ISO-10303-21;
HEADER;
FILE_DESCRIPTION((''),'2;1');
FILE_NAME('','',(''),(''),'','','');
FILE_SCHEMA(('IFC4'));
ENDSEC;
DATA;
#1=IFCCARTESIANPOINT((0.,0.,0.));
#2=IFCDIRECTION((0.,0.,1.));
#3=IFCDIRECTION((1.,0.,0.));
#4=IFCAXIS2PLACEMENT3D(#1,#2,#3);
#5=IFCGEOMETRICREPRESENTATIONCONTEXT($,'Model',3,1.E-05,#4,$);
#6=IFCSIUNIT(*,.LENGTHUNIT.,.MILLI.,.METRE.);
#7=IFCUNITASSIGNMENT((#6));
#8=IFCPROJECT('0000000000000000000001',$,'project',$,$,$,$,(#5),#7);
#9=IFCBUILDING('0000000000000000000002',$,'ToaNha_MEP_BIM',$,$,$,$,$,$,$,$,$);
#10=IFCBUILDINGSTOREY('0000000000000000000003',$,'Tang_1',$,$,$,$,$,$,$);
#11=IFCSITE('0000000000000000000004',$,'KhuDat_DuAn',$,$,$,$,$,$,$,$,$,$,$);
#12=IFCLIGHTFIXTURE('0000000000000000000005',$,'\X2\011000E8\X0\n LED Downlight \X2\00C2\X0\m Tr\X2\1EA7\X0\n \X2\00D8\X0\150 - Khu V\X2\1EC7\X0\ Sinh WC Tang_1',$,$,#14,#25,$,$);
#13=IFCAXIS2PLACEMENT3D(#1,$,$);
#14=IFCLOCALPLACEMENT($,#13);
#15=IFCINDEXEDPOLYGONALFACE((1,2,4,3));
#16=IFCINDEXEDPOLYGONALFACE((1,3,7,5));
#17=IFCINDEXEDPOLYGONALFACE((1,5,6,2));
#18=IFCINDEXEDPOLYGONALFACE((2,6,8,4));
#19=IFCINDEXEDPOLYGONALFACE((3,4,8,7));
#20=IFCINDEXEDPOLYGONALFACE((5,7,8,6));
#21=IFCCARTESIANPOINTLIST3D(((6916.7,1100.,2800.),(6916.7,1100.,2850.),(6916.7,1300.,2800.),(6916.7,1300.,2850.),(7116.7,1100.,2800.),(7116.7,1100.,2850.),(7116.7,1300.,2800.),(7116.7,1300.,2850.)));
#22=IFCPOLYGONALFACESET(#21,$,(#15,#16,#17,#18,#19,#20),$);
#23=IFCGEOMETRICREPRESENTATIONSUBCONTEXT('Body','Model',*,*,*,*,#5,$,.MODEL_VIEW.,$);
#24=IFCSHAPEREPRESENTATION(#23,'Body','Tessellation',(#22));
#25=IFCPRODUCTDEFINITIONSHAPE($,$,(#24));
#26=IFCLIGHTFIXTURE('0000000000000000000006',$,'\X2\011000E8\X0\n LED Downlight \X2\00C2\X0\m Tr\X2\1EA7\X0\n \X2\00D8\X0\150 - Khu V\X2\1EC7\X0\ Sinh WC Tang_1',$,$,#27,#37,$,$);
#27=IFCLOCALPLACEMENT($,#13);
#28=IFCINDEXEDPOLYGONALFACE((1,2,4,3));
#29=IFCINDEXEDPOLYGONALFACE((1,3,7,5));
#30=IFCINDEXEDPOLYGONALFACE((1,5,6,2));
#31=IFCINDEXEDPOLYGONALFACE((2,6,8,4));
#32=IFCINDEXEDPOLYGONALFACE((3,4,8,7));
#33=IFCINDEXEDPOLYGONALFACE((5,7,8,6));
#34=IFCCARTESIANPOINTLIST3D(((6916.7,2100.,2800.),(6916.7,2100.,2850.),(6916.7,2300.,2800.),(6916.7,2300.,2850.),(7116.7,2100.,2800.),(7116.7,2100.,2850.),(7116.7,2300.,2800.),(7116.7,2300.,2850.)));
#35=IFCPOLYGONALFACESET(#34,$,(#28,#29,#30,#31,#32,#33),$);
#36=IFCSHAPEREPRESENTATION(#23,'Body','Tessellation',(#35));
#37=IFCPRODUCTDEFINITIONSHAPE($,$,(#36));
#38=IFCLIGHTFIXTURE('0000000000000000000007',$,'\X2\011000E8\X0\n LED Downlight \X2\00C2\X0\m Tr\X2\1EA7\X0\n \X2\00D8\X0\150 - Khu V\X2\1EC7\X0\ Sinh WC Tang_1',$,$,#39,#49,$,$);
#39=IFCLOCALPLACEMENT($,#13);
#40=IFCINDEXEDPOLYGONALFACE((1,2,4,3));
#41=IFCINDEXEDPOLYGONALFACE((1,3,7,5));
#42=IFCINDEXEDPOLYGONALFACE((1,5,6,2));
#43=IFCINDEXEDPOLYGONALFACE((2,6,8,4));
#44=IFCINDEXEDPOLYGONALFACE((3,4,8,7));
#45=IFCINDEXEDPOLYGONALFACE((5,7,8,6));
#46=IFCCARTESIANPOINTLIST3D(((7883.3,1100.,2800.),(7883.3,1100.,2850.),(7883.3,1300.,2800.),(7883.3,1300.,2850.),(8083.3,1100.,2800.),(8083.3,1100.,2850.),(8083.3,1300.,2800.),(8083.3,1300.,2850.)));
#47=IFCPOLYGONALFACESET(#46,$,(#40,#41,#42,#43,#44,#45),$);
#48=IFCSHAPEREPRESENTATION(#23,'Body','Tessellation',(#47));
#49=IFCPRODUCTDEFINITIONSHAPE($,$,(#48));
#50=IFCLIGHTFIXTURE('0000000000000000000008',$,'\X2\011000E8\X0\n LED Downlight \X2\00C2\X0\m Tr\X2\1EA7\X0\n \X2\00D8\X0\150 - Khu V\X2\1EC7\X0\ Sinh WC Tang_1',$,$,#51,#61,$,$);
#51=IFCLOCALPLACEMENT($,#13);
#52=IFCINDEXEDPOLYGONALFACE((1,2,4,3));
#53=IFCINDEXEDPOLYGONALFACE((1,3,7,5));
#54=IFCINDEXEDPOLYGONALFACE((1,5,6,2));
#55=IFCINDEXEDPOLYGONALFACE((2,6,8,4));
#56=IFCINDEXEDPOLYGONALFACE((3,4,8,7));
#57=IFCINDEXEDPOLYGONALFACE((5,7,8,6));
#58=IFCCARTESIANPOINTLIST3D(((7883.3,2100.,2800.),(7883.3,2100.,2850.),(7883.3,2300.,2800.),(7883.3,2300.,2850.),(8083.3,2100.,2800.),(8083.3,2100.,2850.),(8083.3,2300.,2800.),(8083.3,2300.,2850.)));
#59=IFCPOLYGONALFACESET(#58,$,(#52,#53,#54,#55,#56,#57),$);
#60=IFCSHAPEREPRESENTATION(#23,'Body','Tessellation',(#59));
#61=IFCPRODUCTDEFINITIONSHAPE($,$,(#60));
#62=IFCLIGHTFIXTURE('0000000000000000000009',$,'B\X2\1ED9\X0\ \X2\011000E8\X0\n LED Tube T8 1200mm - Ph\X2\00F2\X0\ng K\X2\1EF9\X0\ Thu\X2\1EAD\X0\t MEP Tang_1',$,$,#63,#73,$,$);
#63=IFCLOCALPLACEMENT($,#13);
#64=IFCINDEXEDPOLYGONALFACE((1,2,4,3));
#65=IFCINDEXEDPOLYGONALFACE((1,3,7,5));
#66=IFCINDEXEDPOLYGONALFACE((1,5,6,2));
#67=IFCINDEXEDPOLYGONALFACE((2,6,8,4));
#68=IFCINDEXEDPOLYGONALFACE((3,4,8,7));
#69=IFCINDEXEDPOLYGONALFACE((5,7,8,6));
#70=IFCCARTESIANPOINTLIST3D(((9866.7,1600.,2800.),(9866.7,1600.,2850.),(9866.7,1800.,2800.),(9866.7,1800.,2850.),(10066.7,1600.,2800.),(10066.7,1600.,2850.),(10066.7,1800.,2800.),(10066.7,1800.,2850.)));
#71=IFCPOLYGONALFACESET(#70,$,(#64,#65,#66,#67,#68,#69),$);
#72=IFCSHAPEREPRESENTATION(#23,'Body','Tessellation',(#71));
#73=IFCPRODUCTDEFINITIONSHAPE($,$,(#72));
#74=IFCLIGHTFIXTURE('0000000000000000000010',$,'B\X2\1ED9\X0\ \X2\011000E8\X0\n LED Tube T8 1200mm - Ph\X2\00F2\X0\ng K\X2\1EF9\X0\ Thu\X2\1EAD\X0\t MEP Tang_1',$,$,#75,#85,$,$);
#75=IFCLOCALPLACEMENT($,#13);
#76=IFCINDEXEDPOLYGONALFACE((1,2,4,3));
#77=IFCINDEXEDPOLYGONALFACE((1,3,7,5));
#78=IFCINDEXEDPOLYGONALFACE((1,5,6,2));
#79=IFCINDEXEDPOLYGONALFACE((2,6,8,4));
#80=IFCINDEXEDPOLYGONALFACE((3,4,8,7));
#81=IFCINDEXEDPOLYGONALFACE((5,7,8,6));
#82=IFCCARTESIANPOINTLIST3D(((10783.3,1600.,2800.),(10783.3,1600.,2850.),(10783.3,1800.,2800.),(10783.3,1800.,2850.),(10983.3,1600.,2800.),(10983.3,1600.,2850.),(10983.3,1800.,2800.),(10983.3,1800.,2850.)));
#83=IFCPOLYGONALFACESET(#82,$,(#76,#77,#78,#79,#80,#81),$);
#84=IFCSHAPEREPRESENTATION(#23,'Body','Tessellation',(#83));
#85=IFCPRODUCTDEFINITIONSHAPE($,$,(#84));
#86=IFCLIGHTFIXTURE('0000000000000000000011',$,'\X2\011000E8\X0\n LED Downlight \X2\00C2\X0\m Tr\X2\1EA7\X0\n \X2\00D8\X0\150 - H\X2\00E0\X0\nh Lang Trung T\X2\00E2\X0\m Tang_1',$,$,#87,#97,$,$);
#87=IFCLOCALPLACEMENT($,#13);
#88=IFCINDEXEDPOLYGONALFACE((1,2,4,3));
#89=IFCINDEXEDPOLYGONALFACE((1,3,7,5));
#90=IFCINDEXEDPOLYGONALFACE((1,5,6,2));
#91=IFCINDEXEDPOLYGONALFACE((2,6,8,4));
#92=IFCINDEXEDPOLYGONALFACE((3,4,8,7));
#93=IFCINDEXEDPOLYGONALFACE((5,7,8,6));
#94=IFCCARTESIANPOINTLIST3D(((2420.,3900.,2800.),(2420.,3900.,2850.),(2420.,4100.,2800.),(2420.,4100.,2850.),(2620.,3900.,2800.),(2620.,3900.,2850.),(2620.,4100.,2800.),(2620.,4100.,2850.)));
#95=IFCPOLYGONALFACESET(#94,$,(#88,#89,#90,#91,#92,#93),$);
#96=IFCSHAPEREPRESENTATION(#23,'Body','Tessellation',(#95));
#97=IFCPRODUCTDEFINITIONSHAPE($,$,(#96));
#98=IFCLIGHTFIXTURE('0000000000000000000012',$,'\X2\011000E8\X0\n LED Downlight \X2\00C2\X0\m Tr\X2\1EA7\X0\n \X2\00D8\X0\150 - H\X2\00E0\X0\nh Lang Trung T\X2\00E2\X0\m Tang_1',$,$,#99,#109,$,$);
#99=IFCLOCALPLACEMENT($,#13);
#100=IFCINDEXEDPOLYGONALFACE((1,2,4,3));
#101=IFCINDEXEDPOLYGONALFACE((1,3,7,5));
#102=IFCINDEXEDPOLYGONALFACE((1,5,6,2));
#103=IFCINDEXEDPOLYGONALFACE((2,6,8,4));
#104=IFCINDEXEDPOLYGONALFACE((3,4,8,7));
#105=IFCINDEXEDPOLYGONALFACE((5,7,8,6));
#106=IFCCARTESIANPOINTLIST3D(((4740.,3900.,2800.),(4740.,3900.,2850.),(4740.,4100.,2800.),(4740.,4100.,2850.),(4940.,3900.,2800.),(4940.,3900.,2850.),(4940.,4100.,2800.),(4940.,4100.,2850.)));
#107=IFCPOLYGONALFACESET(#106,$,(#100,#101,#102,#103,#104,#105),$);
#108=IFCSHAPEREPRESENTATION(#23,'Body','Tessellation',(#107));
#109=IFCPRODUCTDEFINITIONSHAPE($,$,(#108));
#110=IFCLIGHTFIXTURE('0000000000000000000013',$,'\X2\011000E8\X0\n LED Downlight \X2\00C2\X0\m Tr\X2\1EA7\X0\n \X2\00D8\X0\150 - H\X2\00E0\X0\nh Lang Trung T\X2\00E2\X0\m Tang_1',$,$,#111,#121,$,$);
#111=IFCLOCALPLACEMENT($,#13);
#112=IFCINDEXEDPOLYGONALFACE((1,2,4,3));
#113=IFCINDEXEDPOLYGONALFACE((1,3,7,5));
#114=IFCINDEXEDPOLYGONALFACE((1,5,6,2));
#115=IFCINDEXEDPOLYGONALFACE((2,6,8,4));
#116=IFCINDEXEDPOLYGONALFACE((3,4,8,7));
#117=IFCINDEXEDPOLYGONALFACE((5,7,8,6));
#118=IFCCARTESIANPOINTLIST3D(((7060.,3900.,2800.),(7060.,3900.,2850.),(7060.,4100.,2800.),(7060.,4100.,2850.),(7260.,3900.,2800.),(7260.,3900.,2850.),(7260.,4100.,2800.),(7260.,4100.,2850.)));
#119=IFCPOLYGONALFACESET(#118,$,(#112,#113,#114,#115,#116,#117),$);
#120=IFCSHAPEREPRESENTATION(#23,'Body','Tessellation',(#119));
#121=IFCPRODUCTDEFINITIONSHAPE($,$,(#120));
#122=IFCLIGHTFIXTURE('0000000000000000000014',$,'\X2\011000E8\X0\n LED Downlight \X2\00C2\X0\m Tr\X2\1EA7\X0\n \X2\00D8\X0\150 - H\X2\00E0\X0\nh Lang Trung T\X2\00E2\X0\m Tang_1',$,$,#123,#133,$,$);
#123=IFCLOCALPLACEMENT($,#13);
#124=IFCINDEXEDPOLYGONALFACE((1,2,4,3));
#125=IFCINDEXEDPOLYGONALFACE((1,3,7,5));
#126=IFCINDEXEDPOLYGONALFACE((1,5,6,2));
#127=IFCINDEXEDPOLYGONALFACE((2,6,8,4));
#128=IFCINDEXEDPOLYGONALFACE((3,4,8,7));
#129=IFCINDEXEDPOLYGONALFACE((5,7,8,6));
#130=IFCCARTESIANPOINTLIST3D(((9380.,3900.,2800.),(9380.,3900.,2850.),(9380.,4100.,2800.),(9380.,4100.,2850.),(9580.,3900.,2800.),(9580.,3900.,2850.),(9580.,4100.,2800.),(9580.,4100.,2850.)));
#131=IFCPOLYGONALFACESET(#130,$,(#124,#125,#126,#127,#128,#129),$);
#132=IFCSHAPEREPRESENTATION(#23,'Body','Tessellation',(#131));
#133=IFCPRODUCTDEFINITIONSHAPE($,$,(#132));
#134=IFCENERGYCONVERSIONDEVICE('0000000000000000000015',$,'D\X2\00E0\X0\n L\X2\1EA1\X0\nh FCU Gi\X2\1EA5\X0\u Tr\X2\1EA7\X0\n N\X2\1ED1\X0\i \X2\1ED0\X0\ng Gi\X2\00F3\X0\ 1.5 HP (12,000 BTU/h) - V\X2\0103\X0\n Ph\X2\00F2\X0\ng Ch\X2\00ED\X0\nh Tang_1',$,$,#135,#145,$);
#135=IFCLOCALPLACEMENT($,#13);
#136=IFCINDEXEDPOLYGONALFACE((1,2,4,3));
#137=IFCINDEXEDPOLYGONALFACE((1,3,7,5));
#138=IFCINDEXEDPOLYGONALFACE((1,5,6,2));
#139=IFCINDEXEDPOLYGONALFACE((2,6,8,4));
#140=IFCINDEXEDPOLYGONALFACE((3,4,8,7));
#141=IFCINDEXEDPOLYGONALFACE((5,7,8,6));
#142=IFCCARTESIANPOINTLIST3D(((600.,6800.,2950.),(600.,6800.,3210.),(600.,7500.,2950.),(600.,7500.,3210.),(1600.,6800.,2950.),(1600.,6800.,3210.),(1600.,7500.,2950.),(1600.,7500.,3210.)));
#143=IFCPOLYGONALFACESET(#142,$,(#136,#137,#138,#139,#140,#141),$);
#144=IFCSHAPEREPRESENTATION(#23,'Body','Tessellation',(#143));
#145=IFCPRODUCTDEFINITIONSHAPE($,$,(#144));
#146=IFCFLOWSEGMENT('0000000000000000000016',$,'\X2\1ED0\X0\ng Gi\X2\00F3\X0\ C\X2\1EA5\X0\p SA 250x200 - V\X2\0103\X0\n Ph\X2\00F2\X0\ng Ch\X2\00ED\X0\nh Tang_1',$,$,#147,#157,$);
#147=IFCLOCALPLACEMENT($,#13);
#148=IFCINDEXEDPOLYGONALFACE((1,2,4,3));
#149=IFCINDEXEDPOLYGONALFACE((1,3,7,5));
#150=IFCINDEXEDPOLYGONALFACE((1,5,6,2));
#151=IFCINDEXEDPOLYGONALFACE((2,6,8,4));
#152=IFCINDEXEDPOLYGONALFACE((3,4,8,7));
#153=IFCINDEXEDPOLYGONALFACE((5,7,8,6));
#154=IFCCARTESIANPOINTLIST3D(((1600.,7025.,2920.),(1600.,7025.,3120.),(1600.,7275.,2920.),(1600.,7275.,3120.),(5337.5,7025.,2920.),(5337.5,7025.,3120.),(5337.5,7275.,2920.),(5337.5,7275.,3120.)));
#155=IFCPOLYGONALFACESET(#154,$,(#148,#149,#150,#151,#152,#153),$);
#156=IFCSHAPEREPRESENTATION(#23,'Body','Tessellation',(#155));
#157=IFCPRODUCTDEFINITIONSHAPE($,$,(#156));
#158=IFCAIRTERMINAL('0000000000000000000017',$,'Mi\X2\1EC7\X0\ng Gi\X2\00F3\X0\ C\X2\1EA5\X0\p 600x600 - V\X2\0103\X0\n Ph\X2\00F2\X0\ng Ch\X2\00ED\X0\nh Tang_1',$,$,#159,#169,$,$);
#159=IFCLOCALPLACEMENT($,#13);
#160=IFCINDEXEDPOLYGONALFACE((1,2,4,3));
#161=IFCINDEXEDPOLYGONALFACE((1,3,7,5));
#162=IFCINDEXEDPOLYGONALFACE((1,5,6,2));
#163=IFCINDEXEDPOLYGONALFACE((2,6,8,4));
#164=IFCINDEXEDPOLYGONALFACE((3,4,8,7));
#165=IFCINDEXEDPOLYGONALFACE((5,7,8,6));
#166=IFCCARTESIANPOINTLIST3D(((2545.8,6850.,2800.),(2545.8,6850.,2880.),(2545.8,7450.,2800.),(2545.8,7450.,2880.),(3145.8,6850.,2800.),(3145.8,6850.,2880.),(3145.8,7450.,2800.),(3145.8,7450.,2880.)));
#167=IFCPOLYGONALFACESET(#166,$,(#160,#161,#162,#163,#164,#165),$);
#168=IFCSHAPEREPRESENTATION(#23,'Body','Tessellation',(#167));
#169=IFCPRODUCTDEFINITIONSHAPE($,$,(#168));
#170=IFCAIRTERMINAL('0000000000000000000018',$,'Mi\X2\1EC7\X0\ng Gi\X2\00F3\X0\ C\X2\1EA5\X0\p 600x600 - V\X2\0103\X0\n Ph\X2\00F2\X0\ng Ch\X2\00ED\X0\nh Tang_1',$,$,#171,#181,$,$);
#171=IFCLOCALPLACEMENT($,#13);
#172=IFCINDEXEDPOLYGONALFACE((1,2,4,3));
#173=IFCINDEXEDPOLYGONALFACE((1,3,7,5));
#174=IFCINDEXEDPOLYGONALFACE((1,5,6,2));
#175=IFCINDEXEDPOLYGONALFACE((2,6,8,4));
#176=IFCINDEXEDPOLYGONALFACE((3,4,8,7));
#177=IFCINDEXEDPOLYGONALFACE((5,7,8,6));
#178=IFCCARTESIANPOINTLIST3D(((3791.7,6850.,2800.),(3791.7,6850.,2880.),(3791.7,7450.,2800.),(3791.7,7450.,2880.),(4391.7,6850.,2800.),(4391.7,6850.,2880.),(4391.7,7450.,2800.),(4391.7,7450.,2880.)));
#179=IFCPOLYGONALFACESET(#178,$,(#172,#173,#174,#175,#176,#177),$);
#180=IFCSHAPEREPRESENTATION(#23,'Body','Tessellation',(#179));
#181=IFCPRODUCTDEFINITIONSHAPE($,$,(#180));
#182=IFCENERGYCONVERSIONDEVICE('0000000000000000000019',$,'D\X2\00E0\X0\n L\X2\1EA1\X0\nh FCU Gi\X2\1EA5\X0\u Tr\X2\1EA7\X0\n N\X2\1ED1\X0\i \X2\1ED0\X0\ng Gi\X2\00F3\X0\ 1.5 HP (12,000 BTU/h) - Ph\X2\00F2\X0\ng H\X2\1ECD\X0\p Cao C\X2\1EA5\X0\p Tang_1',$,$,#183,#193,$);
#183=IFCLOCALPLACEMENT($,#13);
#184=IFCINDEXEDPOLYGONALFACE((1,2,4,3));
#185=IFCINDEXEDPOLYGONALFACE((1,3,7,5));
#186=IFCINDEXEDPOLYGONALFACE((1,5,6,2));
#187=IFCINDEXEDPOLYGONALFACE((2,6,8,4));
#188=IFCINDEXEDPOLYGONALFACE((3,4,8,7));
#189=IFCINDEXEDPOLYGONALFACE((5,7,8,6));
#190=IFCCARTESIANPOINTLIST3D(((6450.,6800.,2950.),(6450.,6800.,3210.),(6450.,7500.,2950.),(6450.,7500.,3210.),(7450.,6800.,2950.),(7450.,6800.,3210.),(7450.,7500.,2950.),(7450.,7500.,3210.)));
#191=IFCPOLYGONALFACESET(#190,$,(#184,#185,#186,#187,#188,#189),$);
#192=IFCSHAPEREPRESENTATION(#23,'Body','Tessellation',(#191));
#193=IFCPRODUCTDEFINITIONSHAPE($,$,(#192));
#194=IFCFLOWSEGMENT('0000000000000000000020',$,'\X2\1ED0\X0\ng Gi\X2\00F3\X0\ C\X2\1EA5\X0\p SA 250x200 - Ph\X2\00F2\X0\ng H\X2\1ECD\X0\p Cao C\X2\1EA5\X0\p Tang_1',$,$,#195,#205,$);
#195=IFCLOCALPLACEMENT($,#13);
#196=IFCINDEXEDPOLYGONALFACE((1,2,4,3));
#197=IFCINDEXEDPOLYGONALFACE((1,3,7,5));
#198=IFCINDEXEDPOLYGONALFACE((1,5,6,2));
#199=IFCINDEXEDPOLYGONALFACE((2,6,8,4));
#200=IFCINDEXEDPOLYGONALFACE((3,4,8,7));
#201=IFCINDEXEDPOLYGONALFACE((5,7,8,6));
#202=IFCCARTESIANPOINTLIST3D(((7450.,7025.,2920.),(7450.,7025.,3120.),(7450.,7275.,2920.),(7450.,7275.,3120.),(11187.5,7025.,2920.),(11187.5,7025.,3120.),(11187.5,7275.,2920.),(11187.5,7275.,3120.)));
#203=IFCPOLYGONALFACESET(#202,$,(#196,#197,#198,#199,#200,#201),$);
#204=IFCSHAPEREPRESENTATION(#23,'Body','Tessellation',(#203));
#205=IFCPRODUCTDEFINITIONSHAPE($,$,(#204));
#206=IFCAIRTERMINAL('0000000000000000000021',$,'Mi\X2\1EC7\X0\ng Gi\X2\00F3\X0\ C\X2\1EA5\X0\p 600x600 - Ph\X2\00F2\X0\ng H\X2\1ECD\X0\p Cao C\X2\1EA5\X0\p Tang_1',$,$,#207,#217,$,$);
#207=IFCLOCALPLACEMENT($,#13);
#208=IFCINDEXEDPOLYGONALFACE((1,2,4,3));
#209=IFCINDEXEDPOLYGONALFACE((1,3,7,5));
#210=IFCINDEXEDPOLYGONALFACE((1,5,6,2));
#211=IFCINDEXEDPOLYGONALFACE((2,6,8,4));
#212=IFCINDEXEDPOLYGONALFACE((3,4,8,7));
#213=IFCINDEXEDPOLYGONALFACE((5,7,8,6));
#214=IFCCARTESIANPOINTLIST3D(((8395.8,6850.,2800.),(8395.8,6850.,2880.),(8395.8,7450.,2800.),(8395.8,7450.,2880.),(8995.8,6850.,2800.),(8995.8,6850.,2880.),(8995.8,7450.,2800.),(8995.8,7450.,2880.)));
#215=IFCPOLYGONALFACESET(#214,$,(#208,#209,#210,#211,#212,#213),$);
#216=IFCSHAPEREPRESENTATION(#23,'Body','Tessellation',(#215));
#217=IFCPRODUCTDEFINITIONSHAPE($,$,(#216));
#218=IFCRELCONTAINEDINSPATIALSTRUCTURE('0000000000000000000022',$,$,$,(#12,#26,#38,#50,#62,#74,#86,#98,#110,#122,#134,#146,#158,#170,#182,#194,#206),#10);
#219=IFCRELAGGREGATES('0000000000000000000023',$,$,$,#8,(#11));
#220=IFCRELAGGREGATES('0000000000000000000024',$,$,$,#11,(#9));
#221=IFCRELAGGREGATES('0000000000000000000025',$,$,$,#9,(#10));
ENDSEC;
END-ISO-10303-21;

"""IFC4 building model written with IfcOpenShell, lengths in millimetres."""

from ifc_helpers import new_model, si_unit, frame, origin_with_axes, context, subcontext, project, spatial, polyline, outline, extrude, element, save


model = new_model("IFC4")

# Units and contexts
model_context = context("Model", 3, precision=1e-05, world=origin_with_axes())
body_context = subcontext(model_context, "Body", "Model", "MODEL_VIEW")
ifc_project = project(units=[si_unit("LENGTHUNIT", "METRE", prefix="MILLI")], contexts=[model_context])

# Site, building, storey
site = spatial("IfcSite", under=ifc_project, Name="KhuDat_DuAn")
building = spatial("IfcBuilding", under=site, Name="ToaNha_MEP_BIM")
storey = spatial("IfcBuildingStorey", under=building, Name="Tang_1")

# Light fixtures
element("IfcLightFixture", 1, inside=storey, Name="Đèn LED Downlight Âm Trần Ø150 - Khu Vệ Sinh WC Tang_1", context=body_context, shape_type="SweptSolid", body=[
    extrude(outline(polyline([(6916.7, 1100.0), (7116.7, 1100.0), (7116.7, 1300.0), (6916.7, 1300.0), (6916.7, 1100.0)])), frame((0.0, 0.0, 2800.0), z_axis=(0.0, 0.0, 1.0), x_axis=(1.0, 0.0, 0.0)), (0.0, 0.0, 1.0), 50.0),
])
element("IfcLightFixture", 2, inside=storey, Name="Đèn LED Downlight Âm Trần Ø150 - Khu Vệ Sinh WC Tang_1", context=body_context, shape_type="SweptSolid", body=[
    extrude(outline(polyline([(6916.7, 2100.0), (7116.7, 2100.0), (7116.7, 2300.0), (6916.7, 2300.0), (6916.7, 2100.0)])), frame((0.0, 0.0, 2800.0), z_axis=(0.0, 0.0, 1.0), x_axis=(1.0, 0.0, 0.0)), (0.0, 0.0, 1.0), 50.0),
])
element("IfcLightFixture", 3, inside=storey, Name="Đèn LED Downlight Âm Trần Ø150 - Khu Vệ Sinh WC Tang_1", context=body_context, shape_type="SweptSolid", body=[
    extrude(outline(polyline([(7883.3, 1100.0), (8083.3, 1100.0), (8083.3, 1300.0), (7883.3, 1300.0), (7883.3, 1100.0)])), frame((0.0, 0.0, 2800.0), z_axis=(0.0, 0.0, 1.0), x_axis=(1.0, 0.0, 0.0)), (0.0, 0.0, 1.0), 50.0),
])
element("IfcLightFixture", 4, inside=storey, Name="Đèn LED Downlight Âm Trần Ø150 - Khu Vệ Sinh WC Tang_1", context=body_context, shape_type="SweptSolid", body=[
    extrude(outline(polyline([(7883.3, 2100.0), (8083.3, 2100.0), (8083.3, 2300.0), (7883.3, 2300.0), (7883.3, 2100.0)])), frame((0.0, 0.0, 2800.0), z_axis=(0.0, 0.0, 1.0), x_axis=(1.0, 0.0, 0.0)), (0.0, 0.0, 1.0), 50.0),
])
element("IfcLightFixture", 5, inside=storey, Name="Bộ Đèn LED Tube T8 1200mm - Phòng Kỹ Thuật MEP Tang_1", context=body_context, shape_type="SweptSolid", body=[
    extrude(outline(polyline([(9866.7, 1600.0), (10066.7, 1600.0), (10066.7, 1800.0), (9866.7, 1800.0), (9866.7, 1600.0)])), frame((0.0, 0.0, 2800.0), z_axis=(0.0, 0.0, 1.0), x_axis=(1.0, 0.0, 0.0)), (0.0, 0.0, 1.0), 50.0),
])
element("IfcLightFixture", 6, inside=storey, Name="Bộ Đèn LED Tube T8 1200mm - Phòng Kỹ Thuật MEP Tang_1", context=body_context, shape_type="SweptSolid", body=[
    extrude(outline(polyline([(10783.3, 1600.0), (10983.3, 1600.0), (10983.3, 1800.0), (10783.3, 1800.0), (10783.3, 1600.0)])), frame((0.0, 0.0, 2800.0), z_axis=(0.0, 0.0, 1.0), x_axis=(1.0, 0.0, 0.0)), (0.0, 0.0, 1.0), 50.0),
])
element("IfcLightFixture", 7, inside=storey, Name="Đèn LED Downlight Âm Trần Ø150 - Hành Lang Trung Tâm Tang_1", context=body_context, shape_type="SweptSolid", body=[
    extrude(outline(polyline([(2420.0, 3900.0), (2620.0, 3900.0), (2620.0, 4100.0), (2420.0, 4100.0), (2420.0, 3900.0)])), frame((0.0, 0.0, 2800.0), z_axis=(0.0, 0.0, 1.0), x_axis=(1.0, 0.0, 0.0)), (0.0, 0.0, 1.0), 50.0),
])
element("IfcLightFixture", 8, inside=storey, Name="Đèn LED Downlight Âm Trần Ø150 - Hành Lang Trung Tâm Tang_1", context=body_context, shape_type="SweptSolid", body=[
    extrude(outline(polyline([(4740.0, 3900.0), (4940.0, 3900.0), (4940.0, 4100.0), (4740.0, 4100.0), (4740.0, 3900.0)])), frame((0.0, 0.0, 2800.0), z_axis=(0.0, 0.0, 1.0), x_axis=(1.0, 0.0, 0.0)), (0.0, 0.0, 1.0), 50.0),
])
element("IfcLightFixture", 9, inside=storey, Name="Đèn LED Downlight Âm Trần Ø150 - Hành Lang Trung Tâm Tang_1", context=body_context, shape_type="SweptSolid", body=[
    extrude(outline(polyline([(7060.0, 3900.0), (7260.0, 3900.0), (7260.0, 4100.0), (7060.0, 4100.0), (7060.0, 3900.0)])), frame((0.0, 0.0, 2800.0), z_axis=(0.0, 0.0, 1.0), x_axis=(1.0, 0.0, 0.0)), (0.0, 0.0, 1.0), 50.0),
])
element("IfcLightFixture", 10, inside=storey, Name="Đèn LED Downlight Âm Trần Ø150 - Hành Lang Trung Tâm Tang_1", context=body_context, shape_type="SweptSolid", body=[
    extrude(outline(polyline([(9380.0, 3900.0), (9580.0, 3900.0), (9580.0, 4100.0), (9380.0, 4100.0), (9380.0, 3900.0)])), frame((0.0, 0.0, 2800.0), z_axis=(0.0, 0.0, 1.0), x_axis=(1.0, 0.0, 0.0)), (0.0, 0.0, 1.0), 50.0),
])

# Energy conversion device
element("IfcEnergyConversionDevice", 11, inside=storey, Name="Dàn Lạnh FCU Giấu Trần Nối Ống Gió 1.5 HP (12,000 BTU/h) - Văn Phòng Chính Tang_1", context=body_context, shape_type="SweptSolid", body=[
    extrude(outline(polyline([(600.0, 6800.0), (1600.0, 6800.0), (1600.0, 7500.0), (600.0, 7500.0), (600.0, 6800.0)])), frame((0.0, 0.0, 2950.0), z_axis=(0.0, 0.0, 1.0), x_axis=(1.0, 0.0, 0.0)), (0.0, 0.0, 1.0), 260.0),
])

# Flow segment
element("IfcFlowSegment", 12, inside=storey, Name="Ống Gió Cấp SA 250x200 - Văn Phòng Chính Tang_1", context=body_context, shape_type="SweptSolid", body=[
    extrude(outline(polyline([(1600.0, 7025.0), (5337.5, 7025.0), (5337.5, 7275.0), (1600.0, 7275.0), (1600.0, 7025.0)])), frame((0.0, 0.0, 2920.0), z_axis=(0.0, 0.0, 1.0), x_axis=(1.0, 0.0, 0.0)), (0.0, 0.0, 1.0), 200.0),
])

# Air terminals
element("IfcAirTerminal", 13, inside=storey, Name="Miệng Gió Cấp 600x600 - Văn Phòng Chính Tang_1", context=body_context, shape_type="SweptSolid", body=[
    extrude(outline(polyline([(2545.8, 6850.0), (3145.8, 6850.0), (3145.8, 7450.0), (2545.8, 7450.0), (2545.8, 6850.0)])), frame((0.0, 0.0, 2800.0), z_axis=(0.0, 0.0, 1.0), x_axis=(1.0, 0.0, 0.0)), (0.0, 0.0, 1.0), 80.0),
])
element("IfcAirTerminal", 14, inside=storey, Name="Miệng Gió Cấp 600x600 - Văn Phòng Chính Tang_1", context=body_context, shape_type="SweptSolid", body=[
    extrude(outline(polyline([(3791.7, 6850.0), (4391.7, 6850.0), (4391.7, 7450.0), (3791.7, 7450.0), (3791.7, 6850.0)])), frame((0.0, 0.0, 2800.0), z_axis=(0.0, 0.0, 1.0), x_axis=(1.0, 0.0, 0.0)), (0.0, 0.0, 1.0), 80.0),
])

# Energy conversion device
element("IfcEnergyConversionDevice", 15, inside=storey, Name="Dàn Lạnh FCU Giấu Trần Nối Ống Gió 1.5 HP (12,000 BTU/h) - Phòng Họp Cao Cấp Tang_1", context=body_context, shape_type="SweptSolid", body=[
    extrude(outline(polyline([(6450.0, 6800.0), (7450.0, 6800.0), (7450.0, 7500.0), (6450.0, 7500.0), (6450.0, 6800.0)])), frame((0.0, 0.0, 2950.0), z_axis=(0.0, 0.0, 1.0), x_axis=(1.0, 0.0, 0.0)), (0.0, 0.0, 1.0), 260.0),
])

# Flow segment
element("IfcFlowSegment", 16, inside=storey, Name="Ống Gió Cấp SA 250x200 - Phòng Họp Cao Cấp Tang_1", context=body_context, shape_type="SweptSolid", body=[
    extrude(outline(polyline([(7450.0, 7025.0), (11187.5, 7025.0), (11187.5, 7275.0), (7450.0, 7275.0), (7450.0, 7025.0)])), frame((0.0, 0.0, 2920.0), z_axis=(0.0, 0.0, 1.0), x_axis=(1.0, 0.0, 0.0)), (0.0, 0.0, 1.0), 200.0),
])

# Air terminal
element("IfcAirTerminal", 17, inside=storey, Name="Miệng Gió Cấp 600x600 - Phòng Họp Cao Cấp Tang_1", context=body_context, shape_type="SweptSolid", body=[
    extrude(outline(polyline([(8395.8, 6850.0), (8995.8, 6850.0), (8995.8, 7450.0), (8395.8, 7450.0), (8395.8, 6850.0)])), frame((0.0, 0.0, 2800.0), z_axis=(0.0, 0.0, 1.0), x_axis=(1.0, 0.0, 0.0)), (0.0, 0.0, 1.0), 80.0),
])

save(model, "model.ifc")
